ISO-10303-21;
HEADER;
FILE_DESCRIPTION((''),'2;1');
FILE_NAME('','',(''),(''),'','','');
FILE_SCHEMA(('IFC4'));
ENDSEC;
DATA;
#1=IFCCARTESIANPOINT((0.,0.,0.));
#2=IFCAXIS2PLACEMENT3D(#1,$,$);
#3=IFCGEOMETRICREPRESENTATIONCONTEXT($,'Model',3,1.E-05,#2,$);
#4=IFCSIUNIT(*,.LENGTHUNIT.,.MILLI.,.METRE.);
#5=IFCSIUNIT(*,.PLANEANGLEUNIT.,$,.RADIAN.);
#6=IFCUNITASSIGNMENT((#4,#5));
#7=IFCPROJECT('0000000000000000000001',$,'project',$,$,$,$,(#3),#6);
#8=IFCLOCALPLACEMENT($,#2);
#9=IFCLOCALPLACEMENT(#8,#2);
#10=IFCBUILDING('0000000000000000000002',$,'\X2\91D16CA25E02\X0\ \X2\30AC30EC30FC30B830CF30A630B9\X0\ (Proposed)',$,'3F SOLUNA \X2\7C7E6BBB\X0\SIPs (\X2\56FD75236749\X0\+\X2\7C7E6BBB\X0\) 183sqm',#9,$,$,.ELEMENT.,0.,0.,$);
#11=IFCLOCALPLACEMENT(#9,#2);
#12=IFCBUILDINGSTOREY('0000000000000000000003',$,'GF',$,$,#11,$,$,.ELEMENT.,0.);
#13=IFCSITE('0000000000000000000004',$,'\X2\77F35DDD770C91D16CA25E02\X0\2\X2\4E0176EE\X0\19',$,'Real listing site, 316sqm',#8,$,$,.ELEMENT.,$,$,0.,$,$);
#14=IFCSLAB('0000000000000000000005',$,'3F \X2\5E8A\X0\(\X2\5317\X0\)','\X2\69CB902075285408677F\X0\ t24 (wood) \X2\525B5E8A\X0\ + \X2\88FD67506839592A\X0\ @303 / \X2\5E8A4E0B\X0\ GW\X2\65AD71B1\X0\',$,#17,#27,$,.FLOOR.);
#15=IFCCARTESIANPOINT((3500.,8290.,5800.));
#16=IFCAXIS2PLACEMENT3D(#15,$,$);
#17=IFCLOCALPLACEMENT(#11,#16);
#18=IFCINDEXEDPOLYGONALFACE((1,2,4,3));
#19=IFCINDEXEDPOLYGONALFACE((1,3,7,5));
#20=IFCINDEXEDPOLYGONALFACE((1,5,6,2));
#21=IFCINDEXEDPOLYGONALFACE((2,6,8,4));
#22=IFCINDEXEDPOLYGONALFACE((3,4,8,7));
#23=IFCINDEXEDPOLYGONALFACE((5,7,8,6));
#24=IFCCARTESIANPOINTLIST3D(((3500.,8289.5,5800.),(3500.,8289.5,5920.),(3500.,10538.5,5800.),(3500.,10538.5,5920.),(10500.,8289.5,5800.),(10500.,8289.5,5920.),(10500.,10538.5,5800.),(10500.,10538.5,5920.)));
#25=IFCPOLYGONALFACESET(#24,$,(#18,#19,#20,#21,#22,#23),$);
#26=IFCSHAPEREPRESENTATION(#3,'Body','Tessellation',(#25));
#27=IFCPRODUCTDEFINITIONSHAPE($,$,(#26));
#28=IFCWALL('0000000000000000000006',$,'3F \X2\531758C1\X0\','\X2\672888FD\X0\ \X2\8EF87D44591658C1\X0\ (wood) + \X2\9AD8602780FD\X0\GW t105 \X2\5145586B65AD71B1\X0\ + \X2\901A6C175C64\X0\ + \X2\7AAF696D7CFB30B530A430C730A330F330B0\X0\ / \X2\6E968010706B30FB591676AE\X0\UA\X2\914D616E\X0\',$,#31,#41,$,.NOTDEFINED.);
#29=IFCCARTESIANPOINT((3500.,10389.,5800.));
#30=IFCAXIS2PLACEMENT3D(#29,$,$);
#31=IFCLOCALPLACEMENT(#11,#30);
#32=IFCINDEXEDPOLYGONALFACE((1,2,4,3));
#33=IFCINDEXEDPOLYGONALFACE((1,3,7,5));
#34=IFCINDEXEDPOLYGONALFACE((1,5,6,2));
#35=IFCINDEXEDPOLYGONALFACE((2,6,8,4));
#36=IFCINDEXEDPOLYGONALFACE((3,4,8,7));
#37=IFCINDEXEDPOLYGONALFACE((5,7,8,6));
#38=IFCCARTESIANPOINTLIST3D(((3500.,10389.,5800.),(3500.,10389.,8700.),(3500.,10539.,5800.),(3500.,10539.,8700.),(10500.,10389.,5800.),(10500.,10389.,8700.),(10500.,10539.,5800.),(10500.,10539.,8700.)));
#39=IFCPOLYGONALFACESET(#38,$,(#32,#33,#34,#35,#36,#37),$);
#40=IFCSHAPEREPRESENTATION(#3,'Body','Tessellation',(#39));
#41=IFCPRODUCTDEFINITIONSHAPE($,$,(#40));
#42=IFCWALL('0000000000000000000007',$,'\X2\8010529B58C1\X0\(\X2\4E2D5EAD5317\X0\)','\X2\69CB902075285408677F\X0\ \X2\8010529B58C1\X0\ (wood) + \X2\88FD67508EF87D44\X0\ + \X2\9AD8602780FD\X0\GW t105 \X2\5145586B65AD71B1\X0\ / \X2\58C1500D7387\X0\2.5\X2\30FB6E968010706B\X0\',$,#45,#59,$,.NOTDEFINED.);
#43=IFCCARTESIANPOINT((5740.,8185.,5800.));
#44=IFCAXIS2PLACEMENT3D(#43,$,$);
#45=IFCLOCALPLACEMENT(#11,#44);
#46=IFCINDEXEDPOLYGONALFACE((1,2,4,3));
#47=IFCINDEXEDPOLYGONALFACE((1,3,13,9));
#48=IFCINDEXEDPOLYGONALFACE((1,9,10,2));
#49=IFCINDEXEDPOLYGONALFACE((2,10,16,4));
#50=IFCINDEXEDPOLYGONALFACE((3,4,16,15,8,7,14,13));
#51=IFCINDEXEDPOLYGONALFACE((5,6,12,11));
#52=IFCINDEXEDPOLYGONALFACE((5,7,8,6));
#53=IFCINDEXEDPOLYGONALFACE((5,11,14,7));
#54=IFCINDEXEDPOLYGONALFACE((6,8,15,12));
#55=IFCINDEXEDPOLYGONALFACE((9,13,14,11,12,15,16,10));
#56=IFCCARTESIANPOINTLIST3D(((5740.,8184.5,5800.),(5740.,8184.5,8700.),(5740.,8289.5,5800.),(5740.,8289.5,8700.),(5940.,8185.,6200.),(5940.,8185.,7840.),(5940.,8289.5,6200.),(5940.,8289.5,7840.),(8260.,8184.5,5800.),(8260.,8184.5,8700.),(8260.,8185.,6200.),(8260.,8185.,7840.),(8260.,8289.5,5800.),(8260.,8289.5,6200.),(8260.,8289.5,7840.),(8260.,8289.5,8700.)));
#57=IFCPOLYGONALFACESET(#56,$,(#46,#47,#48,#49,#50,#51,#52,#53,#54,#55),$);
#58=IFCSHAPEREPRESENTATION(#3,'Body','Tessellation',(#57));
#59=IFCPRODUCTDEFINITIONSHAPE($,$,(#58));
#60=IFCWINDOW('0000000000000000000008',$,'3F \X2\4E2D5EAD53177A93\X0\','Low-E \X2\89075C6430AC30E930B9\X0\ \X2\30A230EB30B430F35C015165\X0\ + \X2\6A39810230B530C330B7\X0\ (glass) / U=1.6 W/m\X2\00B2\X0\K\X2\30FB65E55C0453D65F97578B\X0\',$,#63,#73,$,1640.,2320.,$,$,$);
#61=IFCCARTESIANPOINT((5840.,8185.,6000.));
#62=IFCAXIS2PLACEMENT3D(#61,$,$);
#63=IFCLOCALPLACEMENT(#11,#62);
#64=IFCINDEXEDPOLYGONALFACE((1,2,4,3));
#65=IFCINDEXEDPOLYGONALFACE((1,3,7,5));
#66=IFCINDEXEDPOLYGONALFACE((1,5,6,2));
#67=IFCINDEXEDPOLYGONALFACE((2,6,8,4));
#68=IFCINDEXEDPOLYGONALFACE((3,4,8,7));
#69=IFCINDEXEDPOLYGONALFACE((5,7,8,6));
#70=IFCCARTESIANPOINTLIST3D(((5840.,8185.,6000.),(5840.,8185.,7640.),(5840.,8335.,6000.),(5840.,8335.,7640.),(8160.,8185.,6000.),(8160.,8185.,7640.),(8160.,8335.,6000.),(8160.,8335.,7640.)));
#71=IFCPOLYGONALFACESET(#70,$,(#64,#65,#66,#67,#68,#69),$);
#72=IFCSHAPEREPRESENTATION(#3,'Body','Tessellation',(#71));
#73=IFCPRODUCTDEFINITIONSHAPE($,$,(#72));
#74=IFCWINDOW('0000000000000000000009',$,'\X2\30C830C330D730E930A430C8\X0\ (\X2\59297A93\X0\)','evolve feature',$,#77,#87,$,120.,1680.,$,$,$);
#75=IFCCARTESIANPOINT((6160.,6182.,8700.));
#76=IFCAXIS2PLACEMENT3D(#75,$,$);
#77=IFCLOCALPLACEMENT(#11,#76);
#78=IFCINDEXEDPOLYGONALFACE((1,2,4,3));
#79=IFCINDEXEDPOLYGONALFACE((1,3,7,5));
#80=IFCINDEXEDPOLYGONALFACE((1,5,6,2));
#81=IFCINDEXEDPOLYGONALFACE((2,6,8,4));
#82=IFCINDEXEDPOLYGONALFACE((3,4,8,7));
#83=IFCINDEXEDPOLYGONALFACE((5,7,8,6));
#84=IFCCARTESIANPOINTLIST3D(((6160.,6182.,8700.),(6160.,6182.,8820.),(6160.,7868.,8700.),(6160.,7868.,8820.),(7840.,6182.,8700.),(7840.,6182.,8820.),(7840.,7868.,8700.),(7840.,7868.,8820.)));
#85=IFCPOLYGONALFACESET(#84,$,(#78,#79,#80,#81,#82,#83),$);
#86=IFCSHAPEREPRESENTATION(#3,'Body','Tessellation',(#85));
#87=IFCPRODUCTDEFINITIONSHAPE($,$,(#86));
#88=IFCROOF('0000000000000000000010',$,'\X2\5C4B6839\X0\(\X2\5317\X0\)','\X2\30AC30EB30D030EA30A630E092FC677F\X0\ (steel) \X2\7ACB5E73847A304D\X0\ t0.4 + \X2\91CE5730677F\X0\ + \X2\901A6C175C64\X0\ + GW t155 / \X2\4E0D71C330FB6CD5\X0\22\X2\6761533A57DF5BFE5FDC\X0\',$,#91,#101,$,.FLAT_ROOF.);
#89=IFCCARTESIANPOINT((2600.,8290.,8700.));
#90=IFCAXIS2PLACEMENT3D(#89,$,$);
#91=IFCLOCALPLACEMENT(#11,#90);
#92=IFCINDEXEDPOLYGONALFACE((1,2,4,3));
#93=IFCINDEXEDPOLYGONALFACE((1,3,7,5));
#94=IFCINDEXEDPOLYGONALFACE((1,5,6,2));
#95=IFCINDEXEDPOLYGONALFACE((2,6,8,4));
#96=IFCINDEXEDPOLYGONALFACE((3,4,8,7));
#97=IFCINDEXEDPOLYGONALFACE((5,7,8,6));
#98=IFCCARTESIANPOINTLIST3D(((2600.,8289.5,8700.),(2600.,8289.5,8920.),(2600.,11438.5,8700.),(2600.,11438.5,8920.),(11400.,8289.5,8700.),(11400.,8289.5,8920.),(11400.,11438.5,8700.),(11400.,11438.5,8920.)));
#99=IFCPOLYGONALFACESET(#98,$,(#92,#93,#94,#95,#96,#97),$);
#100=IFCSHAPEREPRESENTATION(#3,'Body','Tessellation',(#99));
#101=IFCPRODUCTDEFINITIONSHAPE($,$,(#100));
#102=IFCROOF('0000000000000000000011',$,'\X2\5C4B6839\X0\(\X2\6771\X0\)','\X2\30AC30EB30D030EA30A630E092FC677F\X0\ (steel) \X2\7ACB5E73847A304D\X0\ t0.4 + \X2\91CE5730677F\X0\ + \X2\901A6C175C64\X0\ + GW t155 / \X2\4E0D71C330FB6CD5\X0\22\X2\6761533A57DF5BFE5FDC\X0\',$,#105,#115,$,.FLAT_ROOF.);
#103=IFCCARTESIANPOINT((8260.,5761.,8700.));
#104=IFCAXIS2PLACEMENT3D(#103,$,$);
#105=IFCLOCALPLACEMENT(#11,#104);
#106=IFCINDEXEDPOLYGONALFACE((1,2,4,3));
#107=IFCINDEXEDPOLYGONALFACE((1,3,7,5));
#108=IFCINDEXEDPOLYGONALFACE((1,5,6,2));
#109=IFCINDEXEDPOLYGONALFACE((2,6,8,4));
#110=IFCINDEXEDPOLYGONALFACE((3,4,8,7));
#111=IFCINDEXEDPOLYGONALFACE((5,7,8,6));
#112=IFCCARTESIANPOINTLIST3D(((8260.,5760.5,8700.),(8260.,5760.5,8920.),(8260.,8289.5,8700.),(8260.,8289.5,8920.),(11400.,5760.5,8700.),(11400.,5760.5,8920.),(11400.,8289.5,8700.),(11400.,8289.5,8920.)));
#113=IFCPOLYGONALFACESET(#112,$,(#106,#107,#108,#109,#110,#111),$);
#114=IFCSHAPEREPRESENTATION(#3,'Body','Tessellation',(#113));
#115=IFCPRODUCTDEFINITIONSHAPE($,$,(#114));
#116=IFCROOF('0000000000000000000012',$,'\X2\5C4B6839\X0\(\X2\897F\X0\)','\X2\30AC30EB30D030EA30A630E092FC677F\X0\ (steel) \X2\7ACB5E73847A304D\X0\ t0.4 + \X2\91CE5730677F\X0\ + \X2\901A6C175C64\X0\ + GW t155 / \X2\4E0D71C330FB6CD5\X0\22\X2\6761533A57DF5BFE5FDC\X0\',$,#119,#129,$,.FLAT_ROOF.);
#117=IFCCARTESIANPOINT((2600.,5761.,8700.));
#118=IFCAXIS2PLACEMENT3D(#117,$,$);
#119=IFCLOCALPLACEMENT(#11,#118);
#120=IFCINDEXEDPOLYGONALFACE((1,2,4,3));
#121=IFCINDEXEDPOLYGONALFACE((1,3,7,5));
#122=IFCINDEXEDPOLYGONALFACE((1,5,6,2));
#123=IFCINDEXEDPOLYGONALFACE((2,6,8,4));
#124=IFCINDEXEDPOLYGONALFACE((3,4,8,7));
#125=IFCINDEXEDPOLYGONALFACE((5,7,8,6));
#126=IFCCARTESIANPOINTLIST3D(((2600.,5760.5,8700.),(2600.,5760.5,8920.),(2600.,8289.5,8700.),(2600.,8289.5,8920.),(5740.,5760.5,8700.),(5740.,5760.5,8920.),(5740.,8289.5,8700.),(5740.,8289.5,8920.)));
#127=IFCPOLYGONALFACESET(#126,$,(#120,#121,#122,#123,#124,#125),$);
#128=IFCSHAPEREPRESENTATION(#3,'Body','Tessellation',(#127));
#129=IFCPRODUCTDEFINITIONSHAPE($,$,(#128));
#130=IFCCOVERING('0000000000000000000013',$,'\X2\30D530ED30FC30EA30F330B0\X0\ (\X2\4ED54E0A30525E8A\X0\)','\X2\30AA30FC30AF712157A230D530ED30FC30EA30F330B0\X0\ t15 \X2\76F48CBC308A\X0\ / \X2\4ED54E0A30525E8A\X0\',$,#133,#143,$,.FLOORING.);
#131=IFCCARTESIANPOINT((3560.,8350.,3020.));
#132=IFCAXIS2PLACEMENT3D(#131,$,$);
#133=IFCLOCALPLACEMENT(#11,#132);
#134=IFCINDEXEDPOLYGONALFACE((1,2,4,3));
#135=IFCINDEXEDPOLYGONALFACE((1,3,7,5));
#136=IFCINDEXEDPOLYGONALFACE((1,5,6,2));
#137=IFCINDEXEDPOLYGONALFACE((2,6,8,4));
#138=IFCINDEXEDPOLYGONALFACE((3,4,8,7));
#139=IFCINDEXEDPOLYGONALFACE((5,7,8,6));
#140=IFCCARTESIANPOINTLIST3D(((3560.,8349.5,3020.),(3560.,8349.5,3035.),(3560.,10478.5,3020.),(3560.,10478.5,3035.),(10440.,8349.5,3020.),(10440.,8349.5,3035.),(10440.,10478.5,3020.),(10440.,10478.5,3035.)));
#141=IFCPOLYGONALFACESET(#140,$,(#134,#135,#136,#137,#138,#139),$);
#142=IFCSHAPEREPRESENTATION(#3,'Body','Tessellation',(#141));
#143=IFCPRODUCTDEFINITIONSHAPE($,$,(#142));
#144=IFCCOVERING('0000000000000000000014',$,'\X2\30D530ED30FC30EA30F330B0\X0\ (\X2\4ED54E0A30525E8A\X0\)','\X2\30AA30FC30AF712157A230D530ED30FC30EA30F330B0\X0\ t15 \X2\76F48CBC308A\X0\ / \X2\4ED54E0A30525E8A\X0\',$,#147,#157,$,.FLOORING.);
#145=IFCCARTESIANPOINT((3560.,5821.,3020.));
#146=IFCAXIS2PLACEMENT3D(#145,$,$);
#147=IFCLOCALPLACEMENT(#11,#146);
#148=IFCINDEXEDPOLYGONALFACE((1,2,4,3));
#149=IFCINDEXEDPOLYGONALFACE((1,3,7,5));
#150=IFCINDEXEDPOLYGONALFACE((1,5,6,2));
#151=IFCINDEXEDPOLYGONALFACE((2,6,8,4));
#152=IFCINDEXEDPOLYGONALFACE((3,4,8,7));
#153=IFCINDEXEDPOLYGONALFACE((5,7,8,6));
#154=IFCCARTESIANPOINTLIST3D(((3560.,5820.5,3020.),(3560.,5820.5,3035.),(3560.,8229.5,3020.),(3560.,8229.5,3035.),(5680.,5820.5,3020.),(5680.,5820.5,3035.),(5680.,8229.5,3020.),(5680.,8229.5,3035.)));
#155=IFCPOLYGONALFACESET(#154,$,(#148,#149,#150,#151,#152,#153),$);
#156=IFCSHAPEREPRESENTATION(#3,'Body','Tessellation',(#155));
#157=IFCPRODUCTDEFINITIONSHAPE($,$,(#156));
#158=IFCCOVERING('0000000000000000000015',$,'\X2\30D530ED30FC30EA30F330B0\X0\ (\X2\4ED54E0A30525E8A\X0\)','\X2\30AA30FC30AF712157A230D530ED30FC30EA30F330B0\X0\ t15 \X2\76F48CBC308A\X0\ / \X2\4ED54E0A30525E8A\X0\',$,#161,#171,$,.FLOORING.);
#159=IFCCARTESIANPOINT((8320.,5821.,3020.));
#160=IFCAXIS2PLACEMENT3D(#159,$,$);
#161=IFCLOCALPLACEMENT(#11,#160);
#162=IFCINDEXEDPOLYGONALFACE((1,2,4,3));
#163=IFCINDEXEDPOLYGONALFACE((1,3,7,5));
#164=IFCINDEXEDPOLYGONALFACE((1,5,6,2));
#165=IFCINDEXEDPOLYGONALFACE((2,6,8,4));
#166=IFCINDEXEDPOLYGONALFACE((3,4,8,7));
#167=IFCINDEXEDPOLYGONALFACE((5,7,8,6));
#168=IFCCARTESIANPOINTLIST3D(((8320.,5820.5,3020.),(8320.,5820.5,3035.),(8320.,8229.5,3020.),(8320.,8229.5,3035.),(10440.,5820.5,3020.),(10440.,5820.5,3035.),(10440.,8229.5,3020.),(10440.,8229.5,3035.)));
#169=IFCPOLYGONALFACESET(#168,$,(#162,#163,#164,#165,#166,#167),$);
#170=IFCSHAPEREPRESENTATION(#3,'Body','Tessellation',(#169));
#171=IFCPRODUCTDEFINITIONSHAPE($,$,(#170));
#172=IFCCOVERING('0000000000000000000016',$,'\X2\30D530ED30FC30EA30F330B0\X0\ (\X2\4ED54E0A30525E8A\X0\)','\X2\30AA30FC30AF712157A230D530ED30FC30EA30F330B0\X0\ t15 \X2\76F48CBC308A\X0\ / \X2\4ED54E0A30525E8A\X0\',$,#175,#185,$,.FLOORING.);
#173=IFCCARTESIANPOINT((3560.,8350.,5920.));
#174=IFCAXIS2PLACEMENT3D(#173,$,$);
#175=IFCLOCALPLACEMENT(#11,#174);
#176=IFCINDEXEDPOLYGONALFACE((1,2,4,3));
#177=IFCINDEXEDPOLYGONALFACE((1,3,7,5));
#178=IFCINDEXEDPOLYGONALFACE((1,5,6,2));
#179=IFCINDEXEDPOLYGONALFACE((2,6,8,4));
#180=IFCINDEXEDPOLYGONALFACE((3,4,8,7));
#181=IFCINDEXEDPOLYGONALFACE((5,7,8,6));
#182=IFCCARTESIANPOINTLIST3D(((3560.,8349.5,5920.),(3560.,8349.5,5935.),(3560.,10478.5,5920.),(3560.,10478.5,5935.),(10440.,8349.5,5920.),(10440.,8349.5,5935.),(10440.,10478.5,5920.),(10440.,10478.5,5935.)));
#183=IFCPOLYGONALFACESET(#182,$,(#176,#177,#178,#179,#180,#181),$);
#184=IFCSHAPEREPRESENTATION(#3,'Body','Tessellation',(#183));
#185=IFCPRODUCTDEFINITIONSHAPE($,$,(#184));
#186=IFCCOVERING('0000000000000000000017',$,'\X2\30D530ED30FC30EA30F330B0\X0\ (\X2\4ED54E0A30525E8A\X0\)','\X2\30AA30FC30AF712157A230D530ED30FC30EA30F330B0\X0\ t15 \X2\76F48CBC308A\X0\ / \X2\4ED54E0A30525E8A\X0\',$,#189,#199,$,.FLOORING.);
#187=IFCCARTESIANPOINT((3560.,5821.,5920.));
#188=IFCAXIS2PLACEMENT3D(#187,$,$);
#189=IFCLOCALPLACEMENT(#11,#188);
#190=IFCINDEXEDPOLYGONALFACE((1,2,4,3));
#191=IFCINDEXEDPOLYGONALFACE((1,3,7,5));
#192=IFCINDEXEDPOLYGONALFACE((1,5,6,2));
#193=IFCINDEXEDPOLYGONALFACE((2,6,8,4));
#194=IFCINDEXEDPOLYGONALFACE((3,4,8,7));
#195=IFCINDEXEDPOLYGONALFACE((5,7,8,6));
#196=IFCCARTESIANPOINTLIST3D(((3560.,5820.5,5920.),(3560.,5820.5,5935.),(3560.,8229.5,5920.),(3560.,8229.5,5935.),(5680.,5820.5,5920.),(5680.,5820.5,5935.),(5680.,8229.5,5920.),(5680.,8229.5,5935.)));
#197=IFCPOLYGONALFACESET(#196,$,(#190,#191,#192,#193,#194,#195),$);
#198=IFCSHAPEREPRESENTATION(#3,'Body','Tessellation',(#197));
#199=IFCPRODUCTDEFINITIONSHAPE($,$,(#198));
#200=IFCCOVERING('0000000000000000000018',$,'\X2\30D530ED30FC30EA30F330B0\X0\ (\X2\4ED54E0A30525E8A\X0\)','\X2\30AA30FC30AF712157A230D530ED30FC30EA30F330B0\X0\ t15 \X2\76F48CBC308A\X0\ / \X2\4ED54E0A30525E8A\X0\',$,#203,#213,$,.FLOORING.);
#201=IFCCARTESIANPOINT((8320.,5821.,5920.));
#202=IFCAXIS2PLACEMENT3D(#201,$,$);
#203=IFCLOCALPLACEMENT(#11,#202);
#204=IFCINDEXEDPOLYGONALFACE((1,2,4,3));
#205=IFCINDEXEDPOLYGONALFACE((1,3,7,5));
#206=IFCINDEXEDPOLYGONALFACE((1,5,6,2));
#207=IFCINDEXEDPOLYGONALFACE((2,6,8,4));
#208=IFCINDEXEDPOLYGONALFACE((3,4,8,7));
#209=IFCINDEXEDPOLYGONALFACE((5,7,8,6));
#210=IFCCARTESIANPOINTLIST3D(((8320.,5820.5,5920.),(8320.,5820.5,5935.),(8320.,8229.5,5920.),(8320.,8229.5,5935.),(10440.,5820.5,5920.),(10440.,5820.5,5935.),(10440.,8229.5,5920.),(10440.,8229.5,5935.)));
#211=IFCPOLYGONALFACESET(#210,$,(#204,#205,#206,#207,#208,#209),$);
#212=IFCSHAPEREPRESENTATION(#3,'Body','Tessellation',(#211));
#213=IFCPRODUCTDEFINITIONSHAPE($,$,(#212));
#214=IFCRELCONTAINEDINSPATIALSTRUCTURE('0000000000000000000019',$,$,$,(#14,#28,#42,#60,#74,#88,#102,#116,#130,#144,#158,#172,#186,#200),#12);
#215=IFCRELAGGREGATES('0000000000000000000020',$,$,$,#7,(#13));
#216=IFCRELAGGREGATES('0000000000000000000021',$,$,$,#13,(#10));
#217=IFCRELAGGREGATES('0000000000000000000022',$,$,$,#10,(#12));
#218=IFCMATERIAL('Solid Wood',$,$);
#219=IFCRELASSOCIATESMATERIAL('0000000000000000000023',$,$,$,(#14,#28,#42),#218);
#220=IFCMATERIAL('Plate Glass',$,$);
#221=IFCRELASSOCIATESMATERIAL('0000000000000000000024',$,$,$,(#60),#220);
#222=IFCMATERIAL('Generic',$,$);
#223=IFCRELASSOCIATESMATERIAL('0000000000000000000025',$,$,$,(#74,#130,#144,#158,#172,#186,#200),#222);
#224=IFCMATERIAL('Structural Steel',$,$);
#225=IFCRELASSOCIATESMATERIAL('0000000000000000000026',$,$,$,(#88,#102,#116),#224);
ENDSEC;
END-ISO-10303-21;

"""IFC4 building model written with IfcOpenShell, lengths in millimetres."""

from ifc_helpers import new_model, si_unit, frame, frame_2d, origin, place, context, project, spatial, rectangle, extrude, material, element, fill, save


model = new_model("IFC4")

# Units and contexts
model_context = context("Model", 3, precision=1e-05, world=origin())
ifc_project = project(units=[si_unit("LENGTHUNIT", "METRE", prefix="MILLI"), si_unit("PLANEANGLEUNIT", "RADIAN")], contexts=[model_context])

# Site, building, storey
site_placement = place(None, origin())
site = spatial("IfcSite", under=ifc_project, at=site_placement, Name="石川県金沢市2丁目19", ObjectType="Real listing site, 316sqm", CompositionType="ELEMENT", RefElevation=0.0)
building_placement = place(site_placement, origin())
building = spatial("IfcBuilding", under=site, at=building_placement, Name="金沢市 ガレージハウス (Proposed)", ObjectType="3F SOLUNA 籾殻SIPs (国産杉+籾殻) 183sqm", CompositionType="ELEMENT", ElevationOfRefHeight=0.0, ElevationOfTerrain=0.0)
storey_placement = place(building_placement, origin())
storey = spatial("IfcBuildingStorey", under=building, at=storey_placement, Name="GF", CompositionType="ELEMENT", Elevation=0.0)

# Slab
ifc_material_1 = material(Name="Solid Wood")
slab_placement = place(storey_placement, frame((3500.0, 8290.0, 5800.0)))
element("IfcSlab", 1, at=slab_placement, inside=storey, material=ifc_material_1, Name="3F 床(北)", Description="構造用合板 t24 (wood) 剛床 + 製材根太 @303 / 床下 GW断熱", PredefinedType="FLOOR", context=model_context, shape_type="SweptSolid", body=[
    extrude(rectangle(XDim=7000.0, YDim=2249.0, at=frame_2d((3500.0, 1124.0))), frame((3500.0, 8290.0, 5800.0)), (0.0, 0.0, 1.0), 120.0),
])

# Wall
wall_1_placement = place(storey_placement, frame((3500.0, 10389.0, 5800.0)))
element("IfcWall", 2, at=wall_1_placement, inside=storey, material=ifc_material_1, Name="3F 北壁", Description="木製 軸組外壁 (wood) + 高性能GW t105 充填断熱 + 通気層 + 窯業系サイディング / 準耐火・外皮UA配慮", PredefinedType="NOTDEFINED", context=model_context, shape_type="SweptSolid", body=[
    extrude(rectangle(XDim=7000.0, YDim=150.0, at=frame_2d((3500.0, 75.0))), frame((3500.0, 10389.0, 5800.0)), (0.0, 0.0, 1.0), 2900.0),
])

# Wall, opening, window
wall_2_placement = place(storey_placement, frame((5740.0, 8185.0, 5800.0)))
wall_2 = element("IfcWall", 3, at=wall_2_placement, inside=storey, material=ifc_material_1, Name="耐力壁(中庭北)", Description="構造用合板 耐力壁 (wood) + 製材軸組 + 高性能GW t105 充填断熱 / 壁倍率2.5・準耐火", PredefinedType="NOTDEFINED", context=model_context, shape_type="SweptSolid", body=[
    extrude(rectangle(XDim=2520.0, YDim=105.0, at=frame_2d((1260.0, 52.0))), frame((5740.0, 8185.0, 5800.0)), (0.0, 0.0, 1.0), 2900.0),
])
opening_placement = place(storey_placement, frame((5840.0, 8185.0, 6000.0)))
opening = element("IfcOpeningElement", 4, at=opening_placement, cuts=wall_2, PredefinedType="NOTDEFINED", context=model_context, shape_type="SweptSolid", body=[
    extrude(rectangle(XDim=2320.0, YDim=150.0, at=frame_2d((1160.0, 75.0))), frame((5840.0, 8185.0, 6000.0)), (0.0, 0.0, 1.0), 1640.0),
])
ifc_material_2 = material(Name="Plate Glass")
window_1_placement = place(storey_placement, frame((5840.0, 8185.0, 6000.0)))
window_1 = element("IfcWindow", 5, at=window_1_placement, inside=storey, material=ifc_material_2, Name="3F 中庭北窓", Description="Low-E 複層ガラス アルゴン封入 + 樹脂サッシ (glass) / U=1.6 W/m²K・日射取得型", OverallHeight=1640.0, OverallWidth=2320.0, context=model_context, shape_type="SweptSolid", body=[
    extrude(rectangle(XDim=2320.0, YDim=150.0, at=frame_2d((1160.0, 75.0))), frame((5840.0, 8185.0, 6000.0)), (0.0, 0.0, 1.0), 1640.0),
])
fill(opening, window_1)

# Window
ifc_material_3 = material(Name="Generic")
window_2_placement = place(storey_placement, frame((6160.0, 6182.0, 8700.0)))
element("IfcWindow", 6, at=window_2_placement, inside=storey, material=ifc_material_3, Name="トップライト (天窓)", Description="evolve feature", OverallHeight=120.0, OverallWidth=1680.0, context=model_context, shape_type="SweptSolid", body=[
    extrude(rectangle(XDim=1680.0, YDim=1686.0, at=frame_2d((840.0, 843.0))), frame((6160.0, 6182.0, 8700.0)), (0.0, 0.0, 1.0), 120.0),
])

# Roofs
ifc_material_4 = material(Name="Structural Steel")
roof_1_placement = place(storey_placement, frame((2600.0, 8290.0, 8700.0)))
element("IfcRoof", 7, at=roof_1_placement, inside=storey, material=ifc_material_4, Name="屋根(北)", Description="ガルバリウム鋼板 (steel) 立平葺き t0.4 + 野地板 + 通気層 + GW t155 / 不燃・法22条区域対応", PredefinedType="FLAT_ROOF", context=model_context, shape_type="SweptSolid", body=[
    extrude(rectangle(XDim=8800.0, YDim=3149.0, at=frame_2d((4400.0, 1574.0))), frame((2600.0, 8290.0, 8700.0)), (0.0, 0.0, 1.0), 220.0),
])
roof_2_placement = place(storey_placement, frame((8260.0, 5761.0, 8700.0)))
element("IfcRoof", 8, at=roof_2_placement, inside=storey, material=ifc_material_4, Name="屋根(東)", Description="ガルバリウム鋼板 (steel) 立平葺き t0.4 + 野地板 + 通気層 + GW t155 / 不燃・法22条区域対応", PredefinedType="FLAT_ROOF", context=model_context, shape_type="SweptSolid", body=[
    extrude(rectangle(XDim=3140.0, YDim=2529.0, at=frame_2d((1570.0, 1264.0))), frame((8260.0, 5761.0, 8700.0)), (0.0, 0.0, 1.0), 220.0),
])
roof_3_placement = place(storey_placement, frame((2600.0, 5761.0, 8700.0)))
element("IfcRoof", 9, at=roof_3_placement, inside=storey, material=ifc_material_4, Name="屋根(西)", Description="ガルバリウム鋼板 (steel) 立平葺き t0.4 + 野地板 + 通気層 + GW t155 / 不燃・法22条区域対応", PredefinedType="FLAT_ROOF", context=model_context, shape_type="SweptSolid", body=[
    extrude(rectangle(XDim=3140.0, YDim=2529.0, at=frame_2d((1570.0, 1264.0))), frame((2600.0, 5761.0, 8700.0)), (0.0, 0.0, 1.0), 220.0),
])

# Coverings
covering_1_placement = place(storey_placement, frame((3560.0, 8350.0, 3020.0)))
element("IfcCovering", 10, at=covering_1_placement, inside=storey, material=ifc_material_3, Name="フローリング (仕上げ床)", Description="オーク無垢フローリング t15 直貼り / 仕上げ床", PredefinedType="FLOORING", context=model_context, shape_type="SweptSolid", body=[
    extrude(rectangle(XDim=6880.0, YDim=2129.0, at=frame_2d((3440.0, 1064.0))), frame((3560.0, 8350.0, 3020.0)), (0.0, 0.0, 1.0), 15.0),
])
covering_2_placement = place(storey_placement, frame((3560.0, 5821.0, 3020.0)))
element("IfcCovering", 11, at=covering_2_placement, inside=storey, material=ifc_material_3, Name="フローリング (仕上げ床)", Description="オーク無垢フローリング t15 直貼り / 仕上げ床", PredefinedType="FLOORING", context=model_context, shape_type="SweptSolid", body=[
    extrude(rectangle(XDim=2120.0, YDim=2409.0, at=frame_2d((1060.0, 1204.0))), frame((3560.0, 5821.0, 3020.0)), (0.0, 0.0, 1.0), 15.0),
])
covering_3_placement = place(storey_placement, frame((8320.0, 5821.0, 3020.0)))
element("IfcCovering", 12, at=covering_3_placement, inside=storey, material=ifc_material_3, Name="フローリング (仕上げ床)", Description="オーク無垢フローリング t15 直貼り / 仕上げ床", PredefinedType="FLOORING", context=model_context, shape_type="SweptSolid", body=[
    extrude(rectangle(XDim=2120.0, YDim=2409.0, at=frame_2d((1060.0, 1204.0))), frame((8320.0, 5821.0, 3020.0)), (0.0, 0.0, 1.0), 15.0),
])
covering_4_placement = place(storey_placement, frame((3560.0, 8350.0, 5920.0)))
element("IfcCovering", 13, at=covering_4_placement, inside=storey, material=ifc_material_3, Name="フローリング (仕上げ床)", Description="オーク無垢フローリング t15 直貼り / 仕上げ床", PredefinedType="FLOORING", context=model_context, shape_type="SweptSolid", body=[
    extrude(rectangle(XDim=6880.0, YDim=2129.0, at=frame_2d((3440.0, 1064.0))), frame((3560.0, 8350.0, 5920.0)), (0.0, 0.0, 1.0), 15.0),
])
covering_5_placement = place(storey_placement, frame((3560.0, 5821.0, 5920.0)))
element("IfcCovering", 14, at=covering_5_placement, inside=storey, material=ifc_material_3, Name="フローリング (仕上げ床)", Description="オーク無垢フローリング t15 直貼り / 仕上げ床", PredefinedType="FLOORING", context=model_context, shape_type="SweptSolid", body=[
    extrude(rectangle(XDim=2120.0, YDim=2409.0, at=frame_2d((1060.0, 1204.0))), frame((3560.0, 5821.0, 5920.0)), (0.0, 0.0, 1.0), 15.0),
])
covering_6_placement = place(storey_placement, frame((8320.0, 5821.0, 5920.0)))
element("IfcCovering", 15, at=covering_6_placement, inside=storey, material=ifc_material_3, Name="フローリング (仕上げ床)", Description="オーク無垢フローリング t15 直貼り / 仕上げ床", PredefinedType="FLOORING", context=model_context, shape_type="SweptSolid", body=[
    extrude(rectangle(XDim=2120.0, YDim=2409.0, at=frame_2d((1060.0, 1204.0))), frame((8320.0, 5821.0, 5920.0)), (0.0, 0.0, 1.0), 15.0),
])

save(model, "model.ifc")
